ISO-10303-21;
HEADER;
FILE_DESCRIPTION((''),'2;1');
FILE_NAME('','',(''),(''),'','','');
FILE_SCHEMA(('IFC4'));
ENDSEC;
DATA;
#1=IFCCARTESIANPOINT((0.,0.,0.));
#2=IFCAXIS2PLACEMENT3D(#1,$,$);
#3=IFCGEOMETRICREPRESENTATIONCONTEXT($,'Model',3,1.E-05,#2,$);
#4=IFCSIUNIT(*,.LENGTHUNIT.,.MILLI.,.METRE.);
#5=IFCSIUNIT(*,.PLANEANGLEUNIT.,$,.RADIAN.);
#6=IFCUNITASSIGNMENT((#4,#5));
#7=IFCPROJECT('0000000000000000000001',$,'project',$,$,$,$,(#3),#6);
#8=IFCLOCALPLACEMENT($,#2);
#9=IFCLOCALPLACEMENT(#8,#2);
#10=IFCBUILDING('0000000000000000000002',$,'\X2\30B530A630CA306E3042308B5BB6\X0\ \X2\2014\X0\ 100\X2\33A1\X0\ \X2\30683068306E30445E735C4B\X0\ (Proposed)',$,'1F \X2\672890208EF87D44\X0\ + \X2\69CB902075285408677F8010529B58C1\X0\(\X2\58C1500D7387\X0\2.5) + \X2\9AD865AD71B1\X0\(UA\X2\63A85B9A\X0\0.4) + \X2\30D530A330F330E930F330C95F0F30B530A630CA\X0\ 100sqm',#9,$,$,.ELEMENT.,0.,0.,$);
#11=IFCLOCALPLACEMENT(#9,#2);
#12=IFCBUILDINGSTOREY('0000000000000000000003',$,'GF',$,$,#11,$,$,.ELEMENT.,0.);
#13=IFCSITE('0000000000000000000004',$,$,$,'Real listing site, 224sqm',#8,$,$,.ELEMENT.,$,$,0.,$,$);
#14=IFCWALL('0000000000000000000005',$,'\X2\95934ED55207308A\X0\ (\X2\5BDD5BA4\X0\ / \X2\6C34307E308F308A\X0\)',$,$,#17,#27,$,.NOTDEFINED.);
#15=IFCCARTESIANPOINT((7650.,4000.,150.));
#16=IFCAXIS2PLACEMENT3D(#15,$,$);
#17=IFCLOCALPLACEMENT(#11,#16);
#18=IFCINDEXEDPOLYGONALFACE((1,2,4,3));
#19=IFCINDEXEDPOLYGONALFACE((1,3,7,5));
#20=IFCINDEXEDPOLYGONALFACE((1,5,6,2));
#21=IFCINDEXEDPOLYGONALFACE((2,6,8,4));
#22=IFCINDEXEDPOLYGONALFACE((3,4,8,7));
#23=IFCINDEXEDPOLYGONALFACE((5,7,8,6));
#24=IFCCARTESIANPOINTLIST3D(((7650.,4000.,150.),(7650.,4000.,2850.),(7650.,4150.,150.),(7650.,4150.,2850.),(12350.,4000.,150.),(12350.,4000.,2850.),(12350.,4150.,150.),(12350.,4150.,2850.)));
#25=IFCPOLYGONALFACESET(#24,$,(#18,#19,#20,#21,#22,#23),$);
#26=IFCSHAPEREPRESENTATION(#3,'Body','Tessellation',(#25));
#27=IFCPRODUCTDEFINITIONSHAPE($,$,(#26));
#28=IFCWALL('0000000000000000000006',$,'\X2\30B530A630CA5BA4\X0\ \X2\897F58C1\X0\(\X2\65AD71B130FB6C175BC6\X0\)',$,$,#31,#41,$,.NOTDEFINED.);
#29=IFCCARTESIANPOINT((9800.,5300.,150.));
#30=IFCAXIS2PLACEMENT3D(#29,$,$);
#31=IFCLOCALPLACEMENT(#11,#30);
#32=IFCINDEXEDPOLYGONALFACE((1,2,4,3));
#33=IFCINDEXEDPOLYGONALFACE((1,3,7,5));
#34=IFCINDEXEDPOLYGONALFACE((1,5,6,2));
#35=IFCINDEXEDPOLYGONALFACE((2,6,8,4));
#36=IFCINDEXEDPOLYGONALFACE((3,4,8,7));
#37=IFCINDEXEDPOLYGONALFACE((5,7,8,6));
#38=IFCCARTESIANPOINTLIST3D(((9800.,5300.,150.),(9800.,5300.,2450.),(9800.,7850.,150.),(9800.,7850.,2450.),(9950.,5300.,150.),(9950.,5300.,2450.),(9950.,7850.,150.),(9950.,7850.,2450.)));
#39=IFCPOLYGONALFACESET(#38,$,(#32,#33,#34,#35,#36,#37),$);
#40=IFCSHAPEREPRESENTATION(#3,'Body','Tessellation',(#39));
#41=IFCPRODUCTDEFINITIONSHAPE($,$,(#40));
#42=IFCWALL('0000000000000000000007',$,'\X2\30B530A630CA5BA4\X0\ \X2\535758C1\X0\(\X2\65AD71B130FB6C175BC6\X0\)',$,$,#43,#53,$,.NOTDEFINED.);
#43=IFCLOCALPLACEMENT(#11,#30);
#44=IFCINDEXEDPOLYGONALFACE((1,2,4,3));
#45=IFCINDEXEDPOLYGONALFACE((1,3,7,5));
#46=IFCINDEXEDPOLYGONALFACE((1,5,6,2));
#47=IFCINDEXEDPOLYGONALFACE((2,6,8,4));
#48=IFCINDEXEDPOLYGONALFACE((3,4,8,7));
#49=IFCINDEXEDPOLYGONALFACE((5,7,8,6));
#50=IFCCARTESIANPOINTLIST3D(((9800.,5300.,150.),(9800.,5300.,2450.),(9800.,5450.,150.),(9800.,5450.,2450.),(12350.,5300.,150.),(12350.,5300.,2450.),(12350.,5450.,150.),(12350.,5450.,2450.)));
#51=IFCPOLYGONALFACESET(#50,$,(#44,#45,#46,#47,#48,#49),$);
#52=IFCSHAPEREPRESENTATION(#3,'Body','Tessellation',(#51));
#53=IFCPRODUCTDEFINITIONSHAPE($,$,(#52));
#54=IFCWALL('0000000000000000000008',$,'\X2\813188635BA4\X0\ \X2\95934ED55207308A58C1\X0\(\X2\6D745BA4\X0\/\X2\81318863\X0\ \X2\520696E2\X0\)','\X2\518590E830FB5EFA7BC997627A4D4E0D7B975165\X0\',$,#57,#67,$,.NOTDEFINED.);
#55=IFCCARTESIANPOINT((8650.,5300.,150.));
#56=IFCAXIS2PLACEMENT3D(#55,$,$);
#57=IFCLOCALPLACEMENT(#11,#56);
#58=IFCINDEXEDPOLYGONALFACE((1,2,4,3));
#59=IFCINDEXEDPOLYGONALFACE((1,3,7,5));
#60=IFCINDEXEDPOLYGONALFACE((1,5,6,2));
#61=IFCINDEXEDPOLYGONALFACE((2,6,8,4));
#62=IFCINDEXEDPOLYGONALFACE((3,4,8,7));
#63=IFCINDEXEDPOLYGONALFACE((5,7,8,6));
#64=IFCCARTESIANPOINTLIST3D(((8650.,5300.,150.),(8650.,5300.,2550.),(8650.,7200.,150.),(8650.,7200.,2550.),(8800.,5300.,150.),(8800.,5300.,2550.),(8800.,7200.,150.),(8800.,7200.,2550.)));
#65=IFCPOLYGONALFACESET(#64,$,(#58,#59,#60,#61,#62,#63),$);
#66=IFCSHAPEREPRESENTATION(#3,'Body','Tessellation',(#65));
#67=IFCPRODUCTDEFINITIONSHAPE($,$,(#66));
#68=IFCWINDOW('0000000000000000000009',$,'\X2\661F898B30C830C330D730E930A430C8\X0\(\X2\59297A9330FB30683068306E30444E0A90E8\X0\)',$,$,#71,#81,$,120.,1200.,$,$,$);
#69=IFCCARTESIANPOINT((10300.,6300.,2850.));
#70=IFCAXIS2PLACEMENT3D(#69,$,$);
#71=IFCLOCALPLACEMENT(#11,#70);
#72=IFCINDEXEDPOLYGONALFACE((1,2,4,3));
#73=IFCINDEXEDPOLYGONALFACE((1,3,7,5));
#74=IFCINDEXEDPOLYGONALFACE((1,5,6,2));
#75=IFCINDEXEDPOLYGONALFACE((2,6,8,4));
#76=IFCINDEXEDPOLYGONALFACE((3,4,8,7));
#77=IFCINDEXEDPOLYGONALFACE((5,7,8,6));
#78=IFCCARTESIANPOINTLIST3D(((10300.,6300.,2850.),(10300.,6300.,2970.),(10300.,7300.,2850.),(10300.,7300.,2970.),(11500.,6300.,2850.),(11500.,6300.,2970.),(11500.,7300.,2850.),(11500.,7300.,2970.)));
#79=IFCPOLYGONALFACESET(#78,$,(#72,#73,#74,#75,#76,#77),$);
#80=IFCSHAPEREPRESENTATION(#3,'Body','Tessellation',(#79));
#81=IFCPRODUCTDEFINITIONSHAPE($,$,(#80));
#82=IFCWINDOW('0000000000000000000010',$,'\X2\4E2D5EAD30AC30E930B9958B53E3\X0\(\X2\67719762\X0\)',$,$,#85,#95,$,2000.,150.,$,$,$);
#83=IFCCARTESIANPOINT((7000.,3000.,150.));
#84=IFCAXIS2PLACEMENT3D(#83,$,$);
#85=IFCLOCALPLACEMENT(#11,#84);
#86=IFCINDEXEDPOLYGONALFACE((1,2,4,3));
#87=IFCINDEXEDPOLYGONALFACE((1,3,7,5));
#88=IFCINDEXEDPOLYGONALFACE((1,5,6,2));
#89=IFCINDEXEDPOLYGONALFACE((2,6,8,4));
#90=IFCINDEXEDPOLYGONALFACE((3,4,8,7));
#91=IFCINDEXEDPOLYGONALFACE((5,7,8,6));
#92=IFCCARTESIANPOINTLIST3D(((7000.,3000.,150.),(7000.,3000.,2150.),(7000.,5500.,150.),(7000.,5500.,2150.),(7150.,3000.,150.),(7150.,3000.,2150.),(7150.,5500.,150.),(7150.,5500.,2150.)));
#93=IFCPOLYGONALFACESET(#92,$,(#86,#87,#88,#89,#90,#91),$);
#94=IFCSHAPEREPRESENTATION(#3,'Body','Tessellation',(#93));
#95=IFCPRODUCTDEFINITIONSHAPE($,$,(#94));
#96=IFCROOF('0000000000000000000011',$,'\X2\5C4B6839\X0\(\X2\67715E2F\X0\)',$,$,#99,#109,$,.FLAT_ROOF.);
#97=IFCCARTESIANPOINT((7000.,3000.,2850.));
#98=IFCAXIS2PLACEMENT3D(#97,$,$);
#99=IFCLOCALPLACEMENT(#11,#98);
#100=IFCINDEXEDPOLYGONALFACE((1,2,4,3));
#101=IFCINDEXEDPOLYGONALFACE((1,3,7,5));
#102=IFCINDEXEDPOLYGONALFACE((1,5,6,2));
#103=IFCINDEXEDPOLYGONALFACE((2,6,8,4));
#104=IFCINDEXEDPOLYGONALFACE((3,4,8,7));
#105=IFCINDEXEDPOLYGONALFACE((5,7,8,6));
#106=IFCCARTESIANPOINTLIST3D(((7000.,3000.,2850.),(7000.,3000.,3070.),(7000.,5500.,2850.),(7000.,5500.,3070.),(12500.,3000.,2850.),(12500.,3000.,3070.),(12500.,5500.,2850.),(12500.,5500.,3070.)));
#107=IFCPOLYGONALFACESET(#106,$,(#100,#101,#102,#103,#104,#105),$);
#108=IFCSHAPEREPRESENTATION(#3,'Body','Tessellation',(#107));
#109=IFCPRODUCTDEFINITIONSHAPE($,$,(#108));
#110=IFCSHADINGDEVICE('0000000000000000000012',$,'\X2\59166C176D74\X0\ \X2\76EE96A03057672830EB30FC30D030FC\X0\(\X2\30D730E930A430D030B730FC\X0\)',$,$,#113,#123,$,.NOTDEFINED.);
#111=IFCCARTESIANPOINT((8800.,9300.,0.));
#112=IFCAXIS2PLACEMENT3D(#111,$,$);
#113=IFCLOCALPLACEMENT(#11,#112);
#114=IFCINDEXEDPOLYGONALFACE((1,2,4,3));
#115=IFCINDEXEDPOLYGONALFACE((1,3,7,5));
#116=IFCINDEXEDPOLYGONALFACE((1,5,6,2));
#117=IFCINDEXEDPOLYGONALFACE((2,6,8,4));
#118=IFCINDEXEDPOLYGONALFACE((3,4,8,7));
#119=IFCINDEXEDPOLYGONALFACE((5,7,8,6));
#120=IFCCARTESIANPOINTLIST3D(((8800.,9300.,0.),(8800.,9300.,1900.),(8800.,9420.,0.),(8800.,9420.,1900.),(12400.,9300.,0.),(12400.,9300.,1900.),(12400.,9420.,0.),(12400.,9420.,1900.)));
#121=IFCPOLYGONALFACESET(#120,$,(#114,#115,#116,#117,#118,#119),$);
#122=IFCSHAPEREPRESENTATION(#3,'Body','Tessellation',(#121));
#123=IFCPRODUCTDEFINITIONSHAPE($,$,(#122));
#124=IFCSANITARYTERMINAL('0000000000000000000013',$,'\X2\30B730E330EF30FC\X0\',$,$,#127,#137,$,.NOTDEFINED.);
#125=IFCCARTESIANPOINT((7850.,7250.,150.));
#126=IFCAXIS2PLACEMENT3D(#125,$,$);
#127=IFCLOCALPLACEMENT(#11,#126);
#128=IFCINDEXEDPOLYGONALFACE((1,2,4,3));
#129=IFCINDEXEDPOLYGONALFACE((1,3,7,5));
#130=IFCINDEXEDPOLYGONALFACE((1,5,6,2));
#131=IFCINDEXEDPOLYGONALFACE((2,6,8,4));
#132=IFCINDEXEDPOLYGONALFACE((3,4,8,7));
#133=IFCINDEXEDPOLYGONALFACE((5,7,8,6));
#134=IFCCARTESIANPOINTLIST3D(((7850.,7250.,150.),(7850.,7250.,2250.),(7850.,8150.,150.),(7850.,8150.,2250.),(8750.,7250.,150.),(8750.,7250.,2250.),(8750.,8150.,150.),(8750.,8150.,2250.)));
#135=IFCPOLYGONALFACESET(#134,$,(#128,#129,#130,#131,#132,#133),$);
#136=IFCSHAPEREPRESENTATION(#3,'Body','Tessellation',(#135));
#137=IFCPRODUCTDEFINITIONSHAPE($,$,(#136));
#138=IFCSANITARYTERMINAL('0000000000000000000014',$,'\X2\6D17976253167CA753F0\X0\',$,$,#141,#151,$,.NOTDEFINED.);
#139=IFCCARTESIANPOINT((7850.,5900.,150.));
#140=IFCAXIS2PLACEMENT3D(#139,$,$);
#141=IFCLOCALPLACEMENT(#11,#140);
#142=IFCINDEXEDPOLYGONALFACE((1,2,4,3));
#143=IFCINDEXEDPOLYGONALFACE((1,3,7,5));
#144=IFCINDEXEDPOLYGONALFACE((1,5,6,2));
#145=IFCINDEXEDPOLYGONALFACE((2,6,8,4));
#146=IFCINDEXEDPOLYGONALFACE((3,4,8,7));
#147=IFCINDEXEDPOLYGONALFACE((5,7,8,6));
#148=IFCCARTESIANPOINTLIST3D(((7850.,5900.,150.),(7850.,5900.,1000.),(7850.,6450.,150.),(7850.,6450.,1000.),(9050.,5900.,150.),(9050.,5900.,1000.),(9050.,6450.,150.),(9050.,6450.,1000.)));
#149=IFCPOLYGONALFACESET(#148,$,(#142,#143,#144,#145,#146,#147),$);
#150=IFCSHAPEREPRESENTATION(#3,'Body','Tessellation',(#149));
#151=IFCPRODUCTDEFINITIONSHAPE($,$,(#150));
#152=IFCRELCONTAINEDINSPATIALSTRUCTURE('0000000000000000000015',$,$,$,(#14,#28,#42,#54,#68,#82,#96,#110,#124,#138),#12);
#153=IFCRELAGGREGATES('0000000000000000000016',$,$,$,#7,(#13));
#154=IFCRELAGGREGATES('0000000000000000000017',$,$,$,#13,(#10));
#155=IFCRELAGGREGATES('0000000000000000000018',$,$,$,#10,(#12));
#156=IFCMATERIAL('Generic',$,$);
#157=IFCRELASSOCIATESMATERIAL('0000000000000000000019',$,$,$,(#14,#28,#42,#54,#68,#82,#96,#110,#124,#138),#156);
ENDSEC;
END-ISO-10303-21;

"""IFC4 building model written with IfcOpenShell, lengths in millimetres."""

from ifc_helpers import new_model, si_unit, frame, frame_2d, origin, place, context, project, spatial, rectangle, extrude, material, element, save


model = new_model("IFC4")

# Units and contexts
model_context = context("Model", 3, precision=1e-05, world=origin())
ifc_project = project(units=[si_unit("LENGTHUNIT", "METRE", prefix="MILLI"), si_unit("PLANEANGLEUNIT", "RADIAN")], contexts=[model_context])

# Site, building, storey
site_placement = place(None, origin())
site = spatial("IfcSite", under=ifc_project, at=site_placement, ObjectType="Real listing site, 224sqm", CompositionType="ELEMENT", RefElevation=0.0)
building_placement = place(site_placement, origin())
building = spatial("IfcBuilding", under=site, at=building_placement, Name="サウナのある家 — 100㎡ ととのい平屋 (Proposed)", ObjectType="1F 木造軸組 + 構造用合板耐力壁(壁倍率2.5) + 高断熱(UA推定0.4) + フィンランド式サウナ 100sqm", CompositionType="ELEMENT", ElevationOfRefHeight=0.0, ElevationOfTerrain=0.0)
storey_placement = place(building_placement, origin())
storey = spatial("IfcBuildingStorey", under=building, at=storey_placement, Name="GF", CompositionType="ELEMENT", Elevation=0.0)

# Shared definitions
ifc_material = material(Name="Generic")

# Walls
wall_1_placement = place(storey_placement, frame((7650.0, 4000.0, 150.0)))
element("IfcWall", 1, at=wall_1_placement, inside=storey, material=ifc_material, Name="間仕切り (寝室 / 水まわり)", PredefinedType="NOTDEFINED", context=model_context, shape_type="SweptSolid", body=[
    extrude(rectangle(XDim=4700.0, YDim=150.0, at=frame_2d((2350.0, 75.0))), frame((7650.0, 4000.0, 150.0)), (0.0, 0.0, 1.0), 2700.0),
])
wall_2_placement = place(storey_placement, frame((9800.0, 5300.0, 150.0)))
element("IfcWall", 2, at=wall_2_placement, inside=storey, material=ifc_material, Name="サウナ室 西壁(断熱・気密)", PredefinedType="NOTDEFINED", context=model_context, shape_type="SweptSolid", body=[
    extrude(rectangle(XDim=150.0, YDim=2550.0, at=frame_2d((75.0, 1275.0))), frame((9800.0, 5300.0, 150.0)), (0.0, 0.0, 1.0), 2300.0),
])
wall_3_placement = place(storey_placement, frame((9800.0, 5300.0, 150.0)))
element("IfcWall", 3, at=wall_3_placement, inside=storey, material=ifc_material, Name="サウナ室 南壁(断熱・気密)", PredefinedType="NOTDEFINED", context=model_context, shape_type="SweptSolid", body=[
    extrude(rectangle(XDim=2550.0, YDim=150.0, at=frame_2d((1275.0, 75.0))), frame((9800.0, 5300.0, 150.0)), (0.0, 0.0, 1.0), 2300.0),
])
wall_4_placement = place(storey_placement, frame((8650.0, 5300.0, 150.0)))
element("IfcWall", 4, at=wall_4_placement, inside=storey, material=ifc_material, Name="脱衣室 間仕切り壁(浴室/脱衣 分離)", Description="内部・建築面積不算入", PredefinedType="NOTDEFINED", context=model_context, shape_type="SweptSolid", body=[
    extrude(rectangle(XDim=150.0, YDim=1900.0, at=frame_2d((75.0, 950.0))), frame((8650.0, 5300.0, 150.0)), (0.0, 0.0, 1.0), 2400.0),
])

# Windows
window_1_placement = place(storey_placement, frame((10300.0, 6300.0, 2850.0)))
element("IfcWindow", 5, at=window_1_placement, inside=storey, material=ifc_material, Name="星見トップライト(天窓・ととのい上部)", OverallHeight=120.0, OverallWidth=1200.0, context=model_context, shape_type="SweptSolid", body=[
    extrude(rectangle(XDim=1200.0, YDim=1000.0, at=frame_2d((600.0, 500.0))), frame((10300.0, 6300.0, 2850.0)), (0.0, 0.0, 1.0), 120.0),
])
window_2_placement = place(storey_placement, frame((7000.0, 3000.0, 150.0)))
element("IfcWindow", 6, at=window_2_placement, inside=storey, material=ifc_material, Name="中庭ガラス開口(東面)", OverallHeight=2000.0, OverallWidth=150.0, context=model_context, shape_type="SweptSolid", body=[
    extrude(rectangle(XDim=150.0, YDim=2500.0, at=frame_2d((75.0, 1250.0))), frame((7000.0, 3000.0, 150.0)), (0.0, 0.0, 1.0), 2000.0),
])

# Roof
roof_placement = place(storey_placement, frame((7000.0, 3000.0, 2850.0)))
element("IfcRoof", 7, at=roof_placement, inside=storey, material=ifc_material, Name="屋根(東帯)", PredefinedType="FLAT_ROOF", context=model_context, shape_type="SweptSolid", body=[
    extrude(rectangle(XDim=5500.0, YDim=2500.0, at=frame_2d((2750.0, 1250.0))), frame((7000.0, 3000.0, 2850.0)), (0.0, 0.0, 1.0), 220.0),
])

# Shading device
shading_device_placement = place(storey_placement, frame((8800.0, 9300.0, 0.0)))
element("IfcShadingDevice", 8, at=shading_device_placement, inside=storey, material=ifc_material, Name="外気浴 目隠し木ルーバー(プライバシー)", PredefinedType="NOTDEFINED", context=model_context, shape_type="SweptSolid", body=[
    extrude(rectangle(XDim=3600.0, YDim=120.0, at=frame_2d((1800.0, 60.0))), frame((8800.0, 9300.0, 0.0)), (0.0, 0.0, 1.0), 1900.0),
])

# Sanitary terminals
sanitary_terminal_1_placement = place(storey_placement, frame((7850.0, 7250.0, 150.0)))
element("IfcSanitaryTerminal", 9, at=sanitary_terminal_1_placement, inside=storey, material=ifc_material, Name="シャワー", PredefinedType="NOTDEFINED", context=model_context, shape_type="SweptSolid", body=[
    extrude(rectangle(XDim=900.0, YDim=900.0, at=frame_2d((450.0, 450.0))), frame((7850.0, 7250.0, 150.0)), (0.0, 0.0, 1.0), 2100.0),
])
sanitary_terminal_2_placement = place(storey_placement, frame((7850.0, 5900.0, 150.0)))
element("IfcSanitaryTerminal", 10, at=sanitary_terminal_2_placement, inside=storey, material=ifc_material, Name="洗面化粧台", PredefinedType="NOTDEFINED", context=model_context, shape_type="SweptSolid", body=[
    extrude(rectangle(XDim=1200.0, YDim=550.0, at=frame_2d((600.0, 275.0))), frame((7850.0, 5900.0, 150.0)), (0.0, 0.0, 1.0), 850.0),
])

save(model, "model.ifc")
